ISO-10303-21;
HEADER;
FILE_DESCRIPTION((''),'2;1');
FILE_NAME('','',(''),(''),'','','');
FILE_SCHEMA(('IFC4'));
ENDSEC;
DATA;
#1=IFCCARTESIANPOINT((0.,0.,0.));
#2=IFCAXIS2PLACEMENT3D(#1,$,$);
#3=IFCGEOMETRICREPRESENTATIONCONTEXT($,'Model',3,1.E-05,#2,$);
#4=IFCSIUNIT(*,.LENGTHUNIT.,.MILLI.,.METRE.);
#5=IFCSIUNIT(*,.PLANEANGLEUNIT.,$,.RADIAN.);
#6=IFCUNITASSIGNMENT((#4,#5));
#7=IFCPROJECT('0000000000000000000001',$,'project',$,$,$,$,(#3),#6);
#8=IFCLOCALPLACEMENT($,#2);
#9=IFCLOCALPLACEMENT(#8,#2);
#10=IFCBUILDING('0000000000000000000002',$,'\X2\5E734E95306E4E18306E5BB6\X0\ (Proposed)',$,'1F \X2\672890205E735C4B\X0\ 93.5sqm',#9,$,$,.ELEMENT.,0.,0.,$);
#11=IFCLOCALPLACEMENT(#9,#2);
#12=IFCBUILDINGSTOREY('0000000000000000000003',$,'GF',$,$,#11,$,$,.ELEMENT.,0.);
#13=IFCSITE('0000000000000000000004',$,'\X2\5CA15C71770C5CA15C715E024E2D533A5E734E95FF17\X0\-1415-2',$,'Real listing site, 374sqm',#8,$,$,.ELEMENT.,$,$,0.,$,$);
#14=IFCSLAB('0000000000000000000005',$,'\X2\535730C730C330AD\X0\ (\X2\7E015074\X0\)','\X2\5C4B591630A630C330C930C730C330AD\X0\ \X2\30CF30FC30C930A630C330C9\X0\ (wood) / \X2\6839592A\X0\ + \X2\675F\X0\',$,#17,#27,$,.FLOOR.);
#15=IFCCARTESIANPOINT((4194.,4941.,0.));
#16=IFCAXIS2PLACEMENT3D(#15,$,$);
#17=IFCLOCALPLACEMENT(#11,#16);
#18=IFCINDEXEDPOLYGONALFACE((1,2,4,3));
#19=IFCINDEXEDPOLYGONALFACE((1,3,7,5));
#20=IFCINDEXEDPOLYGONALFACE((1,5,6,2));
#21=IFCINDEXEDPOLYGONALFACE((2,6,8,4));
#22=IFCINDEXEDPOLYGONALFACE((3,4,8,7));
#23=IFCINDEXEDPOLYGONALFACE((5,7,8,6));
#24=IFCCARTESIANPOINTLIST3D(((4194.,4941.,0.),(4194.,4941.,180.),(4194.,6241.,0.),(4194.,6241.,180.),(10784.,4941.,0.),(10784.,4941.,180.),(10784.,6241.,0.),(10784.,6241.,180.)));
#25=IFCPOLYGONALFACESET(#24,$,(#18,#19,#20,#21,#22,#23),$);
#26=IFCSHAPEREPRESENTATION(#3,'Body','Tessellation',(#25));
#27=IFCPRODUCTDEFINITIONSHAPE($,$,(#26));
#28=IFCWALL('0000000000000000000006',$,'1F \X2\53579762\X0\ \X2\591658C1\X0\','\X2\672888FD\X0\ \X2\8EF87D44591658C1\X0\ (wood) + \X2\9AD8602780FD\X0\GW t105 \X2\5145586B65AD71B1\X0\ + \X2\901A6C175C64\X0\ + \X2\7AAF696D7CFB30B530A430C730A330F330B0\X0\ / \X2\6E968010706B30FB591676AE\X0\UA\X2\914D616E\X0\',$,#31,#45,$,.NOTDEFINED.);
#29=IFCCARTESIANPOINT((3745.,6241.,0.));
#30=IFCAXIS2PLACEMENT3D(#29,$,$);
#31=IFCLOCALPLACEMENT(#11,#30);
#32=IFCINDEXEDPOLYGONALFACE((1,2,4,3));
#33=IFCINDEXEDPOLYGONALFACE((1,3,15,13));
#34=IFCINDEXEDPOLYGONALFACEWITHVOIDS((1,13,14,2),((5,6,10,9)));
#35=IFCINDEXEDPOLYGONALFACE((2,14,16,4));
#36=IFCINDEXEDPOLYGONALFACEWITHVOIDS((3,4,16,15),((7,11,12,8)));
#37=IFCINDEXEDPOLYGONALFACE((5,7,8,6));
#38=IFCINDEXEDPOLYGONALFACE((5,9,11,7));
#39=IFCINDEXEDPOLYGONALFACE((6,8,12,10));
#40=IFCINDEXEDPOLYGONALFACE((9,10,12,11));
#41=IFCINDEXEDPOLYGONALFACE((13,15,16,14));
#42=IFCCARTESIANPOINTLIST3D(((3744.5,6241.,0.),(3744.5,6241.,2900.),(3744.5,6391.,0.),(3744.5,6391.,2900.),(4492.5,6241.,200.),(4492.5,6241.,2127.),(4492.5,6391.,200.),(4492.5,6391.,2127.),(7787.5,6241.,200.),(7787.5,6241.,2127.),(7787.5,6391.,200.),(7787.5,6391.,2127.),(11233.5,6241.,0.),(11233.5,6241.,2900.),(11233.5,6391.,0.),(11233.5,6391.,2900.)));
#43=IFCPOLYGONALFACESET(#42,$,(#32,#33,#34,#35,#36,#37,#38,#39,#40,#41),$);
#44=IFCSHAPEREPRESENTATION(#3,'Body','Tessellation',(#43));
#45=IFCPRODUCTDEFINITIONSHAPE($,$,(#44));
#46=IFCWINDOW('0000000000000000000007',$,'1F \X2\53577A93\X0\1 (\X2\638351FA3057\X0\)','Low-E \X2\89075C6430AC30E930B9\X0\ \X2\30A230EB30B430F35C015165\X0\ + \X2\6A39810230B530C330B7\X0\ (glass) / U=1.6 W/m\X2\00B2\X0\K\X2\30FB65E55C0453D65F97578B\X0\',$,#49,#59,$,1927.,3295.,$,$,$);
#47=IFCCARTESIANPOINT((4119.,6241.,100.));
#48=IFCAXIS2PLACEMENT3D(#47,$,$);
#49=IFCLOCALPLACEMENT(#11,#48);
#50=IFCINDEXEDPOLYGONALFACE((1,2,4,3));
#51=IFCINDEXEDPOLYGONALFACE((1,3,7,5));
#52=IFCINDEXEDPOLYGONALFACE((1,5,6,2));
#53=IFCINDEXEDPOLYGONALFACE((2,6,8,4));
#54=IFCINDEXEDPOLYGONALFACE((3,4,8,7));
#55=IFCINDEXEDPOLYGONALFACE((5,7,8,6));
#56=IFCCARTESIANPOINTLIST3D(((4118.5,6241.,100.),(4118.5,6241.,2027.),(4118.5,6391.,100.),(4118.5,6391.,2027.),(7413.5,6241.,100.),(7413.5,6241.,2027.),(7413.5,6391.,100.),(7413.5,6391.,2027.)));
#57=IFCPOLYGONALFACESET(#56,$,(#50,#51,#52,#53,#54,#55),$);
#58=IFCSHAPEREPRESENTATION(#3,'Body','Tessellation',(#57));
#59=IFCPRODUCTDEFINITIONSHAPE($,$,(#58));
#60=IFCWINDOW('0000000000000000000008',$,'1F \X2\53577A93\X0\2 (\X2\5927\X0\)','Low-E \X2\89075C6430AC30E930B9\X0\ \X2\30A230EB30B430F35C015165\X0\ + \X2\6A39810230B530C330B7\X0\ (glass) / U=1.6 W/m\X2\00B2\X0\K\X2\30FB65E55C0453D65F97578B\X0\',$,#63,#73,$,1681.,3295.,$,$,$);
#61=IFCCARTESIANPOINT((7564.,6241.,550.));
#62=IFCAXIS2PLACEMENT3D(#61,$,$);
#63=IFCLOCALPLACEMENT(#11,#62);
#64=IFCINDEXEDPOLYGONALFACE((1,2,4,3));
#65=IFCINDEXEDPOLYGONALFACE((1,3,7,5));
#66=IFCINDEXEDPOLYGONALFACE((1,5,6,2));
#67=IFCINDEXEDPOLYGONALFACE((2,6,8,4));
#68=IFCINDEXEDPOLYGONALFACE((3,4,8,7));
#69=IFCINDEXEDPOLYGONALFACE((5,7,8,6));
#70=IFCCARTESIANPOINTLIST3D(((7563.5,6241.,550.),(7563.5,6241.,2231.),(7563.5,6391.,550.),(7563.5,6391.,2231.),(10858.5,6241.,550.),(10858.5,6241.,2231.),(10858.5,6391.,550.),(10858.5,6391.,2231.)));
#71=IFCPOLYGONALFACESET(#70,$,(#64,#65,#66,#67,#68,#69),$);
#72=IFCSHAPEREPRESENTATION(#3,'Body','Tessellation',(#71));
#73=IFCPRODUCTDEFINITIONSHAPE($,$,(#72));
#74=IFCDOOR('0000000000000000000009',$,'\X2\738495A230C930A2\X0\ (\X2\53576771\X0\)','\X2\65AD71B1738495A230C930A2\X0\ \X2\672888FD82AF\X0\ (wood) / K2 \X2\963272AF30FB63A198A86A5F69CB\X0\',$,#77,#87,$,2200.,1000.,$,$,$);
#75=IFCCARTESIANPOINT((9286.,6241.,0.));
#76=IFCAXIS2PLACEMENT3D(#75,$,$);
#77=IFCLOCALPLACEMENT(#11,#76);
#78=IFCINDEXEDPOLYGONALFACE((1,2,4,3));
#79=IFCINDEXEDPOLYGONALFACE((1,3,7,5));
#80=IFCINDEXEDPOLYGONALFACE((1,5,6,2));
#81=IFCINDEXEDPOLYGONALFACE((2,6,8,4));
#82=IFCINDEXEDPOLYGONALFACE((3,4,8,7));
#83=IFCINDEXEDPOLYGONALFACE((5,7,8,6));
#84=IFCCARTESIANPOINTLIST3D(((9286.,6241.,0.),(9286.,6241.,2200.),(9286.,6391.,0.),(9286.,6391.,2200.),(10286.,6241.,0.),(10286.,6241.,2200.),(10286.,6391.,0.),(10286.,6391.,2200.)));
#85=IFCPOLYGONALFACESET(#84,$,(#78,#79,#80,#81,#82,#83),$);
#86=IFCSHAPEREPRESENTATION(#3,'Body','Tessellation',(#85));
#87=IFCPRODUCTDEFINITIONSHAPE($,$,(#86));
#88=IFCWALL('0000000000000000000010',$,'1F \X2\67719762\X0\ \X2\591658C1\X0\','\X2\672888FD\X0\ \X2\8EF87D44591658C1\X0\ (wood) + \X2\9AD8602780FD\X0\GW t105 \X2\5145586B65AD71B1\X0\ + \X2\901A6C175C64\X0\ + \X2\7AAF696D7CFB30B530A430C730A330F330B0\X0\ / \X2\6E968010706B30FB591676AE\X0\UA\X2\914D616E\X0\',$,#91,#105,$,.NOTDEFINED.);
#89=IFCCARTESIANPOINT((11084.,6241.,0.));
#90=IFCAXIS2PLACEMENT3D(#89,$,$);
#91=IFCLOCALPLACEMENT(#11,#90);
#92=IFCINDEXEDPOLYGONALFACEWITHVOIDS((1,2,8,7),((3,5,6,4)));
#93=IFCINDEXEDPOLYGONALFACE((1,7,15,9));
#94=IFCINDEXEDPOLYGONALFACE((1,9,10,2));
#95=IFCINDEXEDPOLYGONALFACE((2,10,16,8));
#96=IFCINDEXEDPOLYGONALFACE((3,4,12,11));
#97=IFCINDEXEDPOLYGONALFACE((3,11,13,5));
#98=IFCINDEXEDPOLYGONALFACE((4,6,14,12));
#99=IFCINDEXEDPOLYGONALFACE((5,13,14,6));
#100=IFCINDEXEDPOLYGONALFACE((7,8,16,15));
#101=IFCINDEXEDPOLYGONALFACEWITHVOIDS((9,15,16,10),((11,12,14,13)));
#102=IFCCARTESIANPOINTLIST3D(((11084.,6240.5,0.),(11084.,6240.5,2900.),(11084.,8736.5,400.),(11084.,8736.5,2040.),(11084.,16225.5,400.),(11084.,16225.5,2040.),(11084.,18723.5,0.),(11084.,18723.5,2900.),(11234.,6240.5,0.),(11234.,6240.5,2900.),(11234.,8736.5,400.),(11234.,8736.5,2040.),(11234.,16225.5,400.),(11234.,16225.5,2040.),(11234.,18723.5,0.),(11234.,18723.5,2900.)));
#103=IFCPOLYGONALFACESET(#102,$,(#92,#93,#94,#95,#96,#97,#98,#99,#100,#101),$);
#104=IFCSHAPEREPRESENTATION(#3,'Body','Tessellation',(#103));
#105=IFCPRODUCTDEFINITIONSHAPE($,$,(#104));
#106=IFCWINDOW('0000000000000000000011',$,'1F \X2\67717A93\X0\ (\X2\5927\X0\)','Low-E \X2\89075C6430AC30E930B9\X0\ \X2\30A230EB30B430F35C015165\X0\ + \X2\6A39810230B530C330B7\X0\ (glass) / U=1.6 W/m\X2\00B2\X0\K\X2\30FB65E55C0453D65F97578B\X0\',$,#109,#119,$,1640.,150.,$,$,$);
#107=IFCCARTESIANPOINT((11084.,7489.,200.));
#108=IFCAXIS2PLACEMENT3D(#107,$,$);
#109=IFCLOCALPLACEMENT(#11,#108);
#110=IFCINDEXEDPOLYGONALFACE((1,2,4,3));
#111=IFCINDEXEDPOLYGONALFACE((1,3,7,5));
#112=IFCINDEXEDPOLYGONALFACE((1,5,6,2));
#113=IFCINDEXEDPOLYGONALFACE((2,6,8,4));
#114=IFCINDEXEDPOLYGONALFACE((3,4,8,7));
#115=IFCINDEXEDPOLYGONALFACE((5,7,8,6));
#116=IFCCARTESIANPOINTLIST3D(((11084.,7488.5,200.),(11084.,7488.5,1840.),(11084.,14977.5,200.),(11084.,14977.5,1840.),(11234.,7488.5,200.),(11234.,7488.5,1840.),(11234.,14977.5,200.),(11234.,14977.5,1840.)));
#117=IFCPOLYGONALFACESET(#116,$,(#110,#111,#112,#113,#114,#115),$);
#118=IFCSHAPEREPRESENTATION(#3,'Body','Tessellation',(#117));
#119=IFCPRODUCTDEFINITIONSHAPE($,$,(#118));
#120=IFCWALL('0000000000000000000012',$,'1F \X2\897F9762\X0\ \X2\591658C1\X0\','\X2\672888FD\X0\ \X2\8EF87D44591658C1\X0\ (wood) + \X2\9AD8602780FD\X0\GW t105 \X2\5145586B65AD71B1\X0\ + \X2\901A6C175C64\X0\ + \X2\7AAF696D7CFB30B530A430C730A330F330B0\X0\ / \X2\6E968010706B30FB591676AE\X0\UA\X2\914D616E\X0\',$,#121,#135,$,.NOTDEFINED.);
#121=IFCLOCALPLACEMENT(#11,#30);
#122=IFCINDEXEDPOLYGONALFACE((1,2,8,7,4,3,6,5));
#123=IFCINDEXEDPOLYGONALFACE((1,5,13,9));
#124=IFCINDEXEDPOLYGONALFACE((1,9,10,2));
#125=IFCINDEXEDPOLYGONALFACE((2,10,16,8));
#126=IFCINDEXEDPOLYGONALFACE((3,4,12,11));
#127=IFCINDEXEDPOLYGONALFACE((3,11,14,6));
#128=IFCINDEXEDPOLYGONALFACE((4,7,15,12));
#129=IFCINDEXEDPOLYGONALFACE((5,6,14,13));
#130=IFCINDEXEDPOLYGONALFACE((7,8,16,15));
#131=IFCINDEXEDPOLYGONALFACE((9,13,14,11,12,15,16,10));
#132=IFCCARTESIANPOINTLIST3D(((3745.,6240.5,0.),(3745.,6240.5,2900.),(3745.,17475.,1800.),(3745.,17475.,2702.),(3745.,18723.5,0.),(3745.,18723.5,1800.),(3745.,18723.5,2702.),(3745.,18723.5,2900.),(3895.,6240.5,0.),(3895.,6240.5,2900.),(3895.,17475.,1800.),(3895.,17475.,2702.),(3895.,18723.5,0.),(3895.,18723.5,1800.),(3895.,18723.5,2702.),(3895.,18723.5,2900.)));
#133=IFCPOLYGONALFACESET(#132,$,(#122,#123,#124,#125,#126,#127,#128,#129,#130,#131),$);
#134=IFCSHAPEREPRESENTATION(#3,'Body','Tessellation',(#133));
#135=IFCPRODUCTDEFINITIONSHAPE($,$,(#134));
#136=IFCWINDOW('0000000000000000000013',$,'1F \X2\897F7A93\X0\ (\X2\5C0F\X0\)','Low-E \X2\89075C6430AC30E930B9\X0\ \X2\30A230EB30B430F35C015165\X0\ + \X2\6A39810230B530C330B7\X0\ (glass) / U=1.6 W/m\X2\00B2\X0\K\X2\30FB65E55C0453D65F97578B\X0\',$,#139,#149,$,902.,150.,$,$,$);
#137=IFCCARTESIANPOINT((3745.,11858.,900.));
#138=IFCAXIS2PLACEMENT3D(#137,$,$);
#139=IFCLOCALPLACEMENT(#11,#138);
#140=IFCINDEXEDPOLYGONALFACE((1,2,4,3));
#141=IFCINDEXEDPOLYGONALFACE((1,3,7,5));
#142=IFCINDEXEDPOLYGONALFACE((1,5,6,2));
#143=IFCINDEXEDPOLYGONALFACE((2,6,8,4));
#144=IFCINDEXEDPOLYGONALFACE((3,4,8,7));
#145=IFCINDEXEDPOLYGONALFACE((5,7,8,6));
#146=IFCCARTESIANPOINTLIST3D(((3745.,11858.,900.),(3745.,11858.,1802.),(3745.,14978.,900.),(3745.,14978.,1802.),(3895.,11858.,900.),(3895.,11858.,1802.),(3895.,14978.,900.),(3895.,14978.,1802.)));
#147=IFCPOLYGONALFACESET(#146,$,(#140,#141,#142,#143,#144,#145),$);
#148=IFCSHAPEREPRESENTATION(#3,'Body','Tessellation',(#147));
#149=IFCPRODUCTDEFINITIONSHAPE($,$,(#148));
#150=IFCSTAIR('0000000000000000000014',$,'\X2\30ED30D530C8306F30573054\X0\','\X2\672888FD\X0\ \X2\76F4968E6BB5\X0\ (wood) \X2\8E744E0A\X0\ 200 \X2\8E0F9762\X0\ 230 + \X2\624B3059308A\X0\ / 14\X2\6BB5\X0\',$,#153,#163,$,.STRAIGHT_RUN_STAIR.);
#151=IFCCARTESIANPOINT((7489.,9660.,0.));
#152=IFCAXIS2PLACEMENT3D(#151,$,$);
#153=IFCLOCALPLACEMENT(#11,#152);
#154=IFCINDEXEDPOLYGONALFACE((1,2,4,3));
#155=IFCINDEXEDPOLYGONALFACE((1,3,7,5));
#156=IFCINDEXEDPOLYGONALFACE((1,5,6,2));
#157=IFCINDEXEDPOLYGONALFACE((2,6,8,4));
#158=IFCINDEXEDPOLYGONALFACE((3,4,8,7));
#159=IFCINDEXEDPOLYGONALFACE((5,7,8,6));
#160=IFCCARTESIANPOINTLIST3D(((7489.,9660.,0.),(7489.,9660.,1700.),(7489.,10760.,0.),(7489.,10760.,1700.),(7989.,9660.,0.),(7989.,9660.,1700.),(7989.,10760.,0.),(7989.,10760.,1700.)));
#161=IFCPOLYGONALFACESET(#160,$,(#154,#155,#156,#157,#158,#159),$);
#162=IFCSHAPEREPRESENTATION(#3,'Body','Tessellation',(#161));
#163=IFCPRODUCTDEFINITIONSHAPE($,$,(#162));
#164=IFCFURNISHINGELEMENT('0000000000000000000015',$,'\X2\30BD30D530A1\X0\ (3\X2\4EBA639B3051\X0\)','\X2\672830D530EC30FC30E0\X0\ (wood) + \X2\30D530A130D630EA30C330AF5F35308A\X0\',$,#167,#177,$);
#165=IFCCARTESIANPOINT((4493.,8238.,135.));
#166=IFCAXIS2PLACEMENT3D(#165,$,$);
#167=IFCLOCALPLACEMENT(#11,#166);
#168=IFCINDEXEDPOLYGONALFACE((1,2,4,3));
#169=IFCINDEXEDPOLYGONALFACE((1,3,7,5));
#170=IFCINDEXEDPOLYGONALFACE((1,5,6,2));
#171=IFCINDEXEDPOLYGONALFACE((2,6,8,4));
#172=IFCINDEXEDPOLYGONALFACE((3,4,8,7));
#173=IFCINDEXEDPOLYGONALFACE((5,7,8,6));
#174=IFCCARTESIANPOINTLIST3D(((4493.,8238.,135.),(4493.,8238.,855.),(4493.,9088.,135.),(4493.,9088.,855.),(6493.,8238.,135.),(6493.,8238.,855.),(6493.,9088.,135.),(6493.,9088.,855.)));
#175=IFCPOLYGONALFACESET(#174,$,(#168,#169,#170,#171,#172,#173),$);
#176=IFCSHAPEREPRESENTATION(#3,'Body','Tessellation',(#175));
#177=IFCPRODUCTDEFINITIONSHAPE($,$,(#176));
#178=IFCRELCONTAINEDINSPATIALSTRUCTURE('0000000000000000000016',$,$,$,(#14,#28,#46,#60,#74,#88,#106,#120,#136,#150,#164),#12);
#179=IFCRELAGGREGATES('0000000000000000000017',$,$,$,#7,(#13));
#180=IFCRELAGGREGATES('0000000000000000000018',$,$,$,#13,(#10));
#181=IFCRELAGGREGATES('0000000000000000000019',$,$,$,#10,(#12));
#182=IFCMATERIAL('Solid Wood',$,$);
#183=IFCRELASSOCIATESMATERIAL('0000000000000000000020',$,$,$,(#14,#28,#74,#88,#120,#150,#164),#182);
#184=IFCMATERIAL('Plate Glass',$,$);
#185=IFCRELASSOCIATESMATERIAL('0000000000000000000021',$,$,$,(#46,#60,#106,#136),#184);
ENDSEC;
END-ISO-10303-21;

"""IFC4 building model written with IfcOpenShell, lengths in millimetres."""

from ifc_helpers import new_model, si_unit, frame, frame_2d, origin, place, context, project, spatial, rectangle, extrude, material, element, fill, save


model = new_model("IFC4")

# Units and contexts
model_context = context("Model", 3, precision=1e-05, world=origin())
ifc_project = project(units=[si_unit("LENGTHUNIT", "METRE", prefix="MILLI"), si_unit("PLANEANGLEUNIT", "RADIAN")], contexts=[model_context])

# Site, building, storey
site_placement = place(None, origin())
site = spatial("IfcSite", under=ifc_project, at=site_placement, Name="岡山県岡山市中区平井７-1415-2", ObjectType="Real listing site, 374sqm", CompositionType="ELEMENT", RefElevation=0.0)
building_placement = place(site_placement, origin())
building = spatial("IfcBuilding", under=site, at=building_placement, Name="平井の丘の家 (Proposed)", ObjectType="1F 木造平屋 93.5sqm", CompositionType="ELEMENT", ElevationOfRefHeight=0.0, ElevationOfTerrain=0.0)
storey_placement = place(building_placement, origin())
storey = spatial("IfcBuildingStorey", under=building, at=storey_placement, Name="GF", CompositionType="ELEMENT", Elevation=0.0)

# Slab
ifc_material_1 = material(Name="Solid Wood")
slab_1_placement = place(storey_placement, frame((4194.0, 4941.0, 0.0)))
element("IfcSlab", 1, at=slab_1_placement, inside=storey, material=ifc_material_1, Name="南デッキ (縁側)", Description="屋外ウッドデッキ ハードウッド (wood) / 根太 + 束", PredefinedType="FLOOR", context=model_context, shape_type="SweptSolid", body=[
    extrude(rectangle(XDim=6590.0, YDim=1300.0, at=frame_2d((3295.0, 650.0))), frame((4194.0, 4941.0, 0.0)), (0.0, 0.0, 1.0), 180.0),
])

# Wall, openings, windows, door
wall_1_placement = place(storey_placement, frame((3745.0, 6241.0, 0.0)))
wall_1 = element("IfcWall", 2, at=wall_1_placement, inside=storey, material=ifc_material_1, Name="1F 南面 外壁", Description="木製 軸組外壁 (wood) + 高性能GW t105 充填断熱 + 通気層 + 窯業系サイディング / 準耐火・外皮UA配慮", PredefinedType="NOTDEFINED", context=model_context, shape_type="SweptSolid", body=[
    extrude(rectangle(XDim=7489.0, YDim=150.0, at=frame_2d((3744.0, 75.0))), frame((3745.0, 6241.0, 0.0)), (0.0, 0.0, 1.0), 2900.0),
])
opening_1_placement = place(storey_placement, frame((4119.0, 6241.0, 100.0)))
opening_1 = element("IfcOpeningElement", 3, at=opening_1_placement, cuts=wall_1, PredefinedType="NOTDEFINED", context=model_context, shape_type="SweptSolid", body=[
    extrude(rectangle(XDim=3295.0, YDim=150.0, at=frame_2d((1647.0, 75.0))), frame((4119.0, 6241.0, 100.0)), (0.0, 0.0, 1.0), 1927.0),
])
opening_2_placement = place(storey_placement, frame((7564.0, 6241.0, 550.0)))
opening_2 = element("IfcOpeningElement", 4, at=opening_2_placement, cuts=wall_1, PredefinedType="NOTDEFINED", context=model_context, shape_type="SweptSolid", body=[
    extrude(rectangle(XDim=3295.0, YDim=150.0, at=frame_2d((1647.0, 75.0))), frame((7564.0, 6241.0, 550.0)), (0.0, 0.0, 1.0), 1681.0),
])
opening_3_placement = place(storey_placement, frame((9286.0, 6241.0, 0.0)))
opening_3 = element("IfcOpeningElement", 5, at=opening_3_placement, cuts=wall_1, PredefinedType="NOTDEFINED", context=model_context, shape_type="SweptSolid", body=[
    extrude(rectangle(XDim=1000.0, YDim=150.0, at=frame_2d((500.0, 75.0))), frame((9286.0, 6241.0, 0.0)), (0.0, 0.0, 1.0), 2200.0),
])
ifc_material_2 = material(Name="Plate Glass")
window_1_placement = place(storey_placement, frame((4119.0, 6241.0, 100.0)))
window_1 = element("IfcWindow", 6, at=window_1_placement, inside=storey, material=ifc_material_2, Name="1F 南窓1 (掃出し)", Description="Low-E 複層ガラス アルゴン封入 + 樹脂サッシ (glass) / U=1.6 W/m²K・日射取得型", OverallHeight=1927.0, OverallWidth=3295.0, context=model_context, shape_type="SweptSolid", body=[
    extrude(rectangle(XDim=3295.0, YDim=150.0, at=frame_2d((1647.0, 75.0))), frame((4119.0, 6241.0, 100.0)), (0.0, 0.0, 1.0), 1927.0),
])
fill(opening_1, window_1)
window_2_placement = place(storey_placement, frame((7564.0, 6241.0, 550.0)))
window_2 = element("IfcWindow", 7, at=window_2_placement, inside=storey, material=ifc_material_2, Name="1F 南窓2 (大)", Description="Low-E 複層ガラス アルゴン封入 + 樹脂サッシ (glass) / U=1.6 W/m²K・日射取得型", OverallHeight=1681.0, OverallWidth=3295.0, context=model_context, shape_type="SweptSolid", body=[
    extrude(rectangle(XDim=3295.0, YDim=150.0, at=frame_2d((1647.0, 75.0))), frame((7564.0, 6241.0, 550.0)), (0.0, 0.0, 1.0), 1681.0),
])
fill(opening_2, window_2)
door_placement = place(storey_placement, frame((9286.0, 6241.0, 0.0)))
door = element("IfcDoor", 8, at=door_placement, inside=storey, material=ifc_material_1, Name="玄関ドア (南東)", Description="断熱玄関ドア 木製芯 (wood) / K2 防犯・採風機構", OverallHeight=2200.0, OverallWidth=1000.0, context=model_context, shape_type="SweptSolid", body=[
    extrude(rectangle(XDim=1000.0, YDim=150.0, at=frame_2d((500.0, 75.0))), frame((9286.0, 6241.0, 0.0)), (0.0, 0.0, 1.0), 2200.0),
])
fill(opening_3, door)

# Walls, openings, windows
wall_2_placement = place(storey_placement, frame((11084.0, 6241.0, 0.0)))
wall_2 = element("IfcWall", 9, at=wall_2_placement, inside=storey, material=ifc_material_1, Name="1F 東面 外壁", Description="木製 軸組外壁 (wood) + 高性能GW t105 充填断熱 + 通気層 + 窯業系サイディング / 準耐火・外皮UA配慮", PredefinedType="NOTDEFINED", context=model_context, shape_type="SweptSolid", body=[
    extrude(rectangle(XDim=150.0, YDim=12483.0, at=frame_2d((75.0, 6241.0))), frame((11084.0, 6241.0, 0.0)), (0.0, 0.0, 1.0), 2900.0),
])
opening_4_placement = place(storey_placement, frame((11084.0, 7489.0, 200.0)))
opening_4 = element("IfcOpeningElement", 10, at=opening_4_placement, cuts=wall_2, PredefinedType="NOTDEFINED", context=model_context, shape_type="SweptSolid", body=[
    extrude(rectangle(XDim=150.0, YDim=7489.0, at=frame_2d((75.0, 3744.0))), frame((11084.0, 7489.0, 200.0)), (0.0, 0.0, 1.0), 1640.0),
])
window_3_placement = place(storey_placement, frame((11084.0, 7489.0, 200.0)))
window_3 = element("IfcWindow", 11, at=window_3_placement, inside=storey, material=ifc_material_2, Name="1F 東窓 (大)", Description="Low-E 複層ガラス アルゴン封入 + 樹脂サッシ (glass) / U=1.6 W/m²K・日射取得型", OverallHeight=1640.0, OverallWidth=150.0, context=model_context, shape_type="SweptSolid", body=[
    extrude(rectangle(XDim=150.0, YDim=7489.0, at=frame_2d((75.0, 3744.0))), frame((11084.0, 7489.0, 200.0)), (0.0, 0.0, 1.0), 1640.0),
])
fill(opening_4, window_3)
wall_3_placement = place(storey_placement, frame((3745.0, 6241.0, 0.0)))
wall_3 = element("IfcWall", 12, at=wall_3_placement, inside=storey, material=ifc_material_1, Name="1F 西面 外壁", Description="木製 軸組外壁 (wood) + 高性能GW t105 充填断熱 + 通気層 + 窯業系サイディング / 準耐火・外皮UA配慮", PredefinedType="NOTDEFINED", context=model_context, shape_type="SweptSolid", body=[
    extrude(rectangle(XDim=150.0, YDim=12483.0, at=frame_2d((75.0, 6241.0))), frame((3745.0, 6241.0, 0.0)), (0.0, 0.0, 1.0), 2900.0),
])
opening_5_placement = place(storey_placement, frame((3745.0, 11858.0, 900.0)))
opening_5 = element("IfcOpeningElement", 13, at=opening_5_placement, cuts=wall_3, PredefinedType="NOTDEFINED", context=model_context, shape_type="SweptSolid", body=[
    extrude(rectangle(XDim=150.0, YDim=3120.0, at=frame_2d((75.0, 1560.0))), frame((3745.0, 11858.0, 900.0)), (0.0, 0.0, 1.0), 902.0),
])
window_4_placement = place(storey_placement, frame((3745.0, 11858.0, 900.0)))
window_4 = element("IfcWindow", 14, at=window_4_placement, inside=storey, material=ifc_material_2, Name="1F 西窓 (小)", Description="Low-E 複層ガラス アルゴン封入 + 樹脂サッシ (glass) / U=1.6 W/m²K・日射取得型", OverallHeight=902.0, OverallWidth=150.0, context=model_context, shape_type="SweptSolid", body=[
    extrude(rectangle(XDim=150.0, YDim=3120.0, at=frame_2d((75.0, 1560.0))), frame((3745.0, 11858.0, 900.0)), (0.0, 0.0, 1.0), 902.0),
])
fill(opening_5, window_4)

# Stair
stair_placement = place(storey_placement, frame((7489.0, 9660.0, 0.0)))
element("IfcStair", 15, at=stair_placement, inside=storey, material=ifc_material_1, Name="ロフトはしご", Description="木製 直階段 (wood) 蹴上 200 踏面 230 + 手すり / 14段", PredefinedType="STRAIGHT_RUN_STAIR", context=model_context, shape_type="SweptSolid", body=[
    extrude(rectangle(XDim=500.0, YDim=1100.0, at=frame_2d((250.0, 550.0))), frame((7489.0, 9660.0, 0.0)), (0.0, 0.0, 1.0), 1700.0),
])

# Furnishing element
furnishing_1_placement = place(storey_placement, frame((4493.0, 8238.0, 135.0)))
element("IfcFurnishingElement", 16, at=furnishing_1_placement, inside=storey, material=ifc_material_1, Name="ソファ (3人掛け)", Description="木フレーム (wood) + ファブリック張り", context=model_context, shape_type="SweptSolid", body=[
    extrude(rectangle(XDim=2000.0, YDim=850.0, at=frame_2d((1000.0, 425.0))), frame((4493.0, 8238.0, 135.0)), (0.0, 0.0, 1.0), 720.0),
])

save(model, "model.ifc")
